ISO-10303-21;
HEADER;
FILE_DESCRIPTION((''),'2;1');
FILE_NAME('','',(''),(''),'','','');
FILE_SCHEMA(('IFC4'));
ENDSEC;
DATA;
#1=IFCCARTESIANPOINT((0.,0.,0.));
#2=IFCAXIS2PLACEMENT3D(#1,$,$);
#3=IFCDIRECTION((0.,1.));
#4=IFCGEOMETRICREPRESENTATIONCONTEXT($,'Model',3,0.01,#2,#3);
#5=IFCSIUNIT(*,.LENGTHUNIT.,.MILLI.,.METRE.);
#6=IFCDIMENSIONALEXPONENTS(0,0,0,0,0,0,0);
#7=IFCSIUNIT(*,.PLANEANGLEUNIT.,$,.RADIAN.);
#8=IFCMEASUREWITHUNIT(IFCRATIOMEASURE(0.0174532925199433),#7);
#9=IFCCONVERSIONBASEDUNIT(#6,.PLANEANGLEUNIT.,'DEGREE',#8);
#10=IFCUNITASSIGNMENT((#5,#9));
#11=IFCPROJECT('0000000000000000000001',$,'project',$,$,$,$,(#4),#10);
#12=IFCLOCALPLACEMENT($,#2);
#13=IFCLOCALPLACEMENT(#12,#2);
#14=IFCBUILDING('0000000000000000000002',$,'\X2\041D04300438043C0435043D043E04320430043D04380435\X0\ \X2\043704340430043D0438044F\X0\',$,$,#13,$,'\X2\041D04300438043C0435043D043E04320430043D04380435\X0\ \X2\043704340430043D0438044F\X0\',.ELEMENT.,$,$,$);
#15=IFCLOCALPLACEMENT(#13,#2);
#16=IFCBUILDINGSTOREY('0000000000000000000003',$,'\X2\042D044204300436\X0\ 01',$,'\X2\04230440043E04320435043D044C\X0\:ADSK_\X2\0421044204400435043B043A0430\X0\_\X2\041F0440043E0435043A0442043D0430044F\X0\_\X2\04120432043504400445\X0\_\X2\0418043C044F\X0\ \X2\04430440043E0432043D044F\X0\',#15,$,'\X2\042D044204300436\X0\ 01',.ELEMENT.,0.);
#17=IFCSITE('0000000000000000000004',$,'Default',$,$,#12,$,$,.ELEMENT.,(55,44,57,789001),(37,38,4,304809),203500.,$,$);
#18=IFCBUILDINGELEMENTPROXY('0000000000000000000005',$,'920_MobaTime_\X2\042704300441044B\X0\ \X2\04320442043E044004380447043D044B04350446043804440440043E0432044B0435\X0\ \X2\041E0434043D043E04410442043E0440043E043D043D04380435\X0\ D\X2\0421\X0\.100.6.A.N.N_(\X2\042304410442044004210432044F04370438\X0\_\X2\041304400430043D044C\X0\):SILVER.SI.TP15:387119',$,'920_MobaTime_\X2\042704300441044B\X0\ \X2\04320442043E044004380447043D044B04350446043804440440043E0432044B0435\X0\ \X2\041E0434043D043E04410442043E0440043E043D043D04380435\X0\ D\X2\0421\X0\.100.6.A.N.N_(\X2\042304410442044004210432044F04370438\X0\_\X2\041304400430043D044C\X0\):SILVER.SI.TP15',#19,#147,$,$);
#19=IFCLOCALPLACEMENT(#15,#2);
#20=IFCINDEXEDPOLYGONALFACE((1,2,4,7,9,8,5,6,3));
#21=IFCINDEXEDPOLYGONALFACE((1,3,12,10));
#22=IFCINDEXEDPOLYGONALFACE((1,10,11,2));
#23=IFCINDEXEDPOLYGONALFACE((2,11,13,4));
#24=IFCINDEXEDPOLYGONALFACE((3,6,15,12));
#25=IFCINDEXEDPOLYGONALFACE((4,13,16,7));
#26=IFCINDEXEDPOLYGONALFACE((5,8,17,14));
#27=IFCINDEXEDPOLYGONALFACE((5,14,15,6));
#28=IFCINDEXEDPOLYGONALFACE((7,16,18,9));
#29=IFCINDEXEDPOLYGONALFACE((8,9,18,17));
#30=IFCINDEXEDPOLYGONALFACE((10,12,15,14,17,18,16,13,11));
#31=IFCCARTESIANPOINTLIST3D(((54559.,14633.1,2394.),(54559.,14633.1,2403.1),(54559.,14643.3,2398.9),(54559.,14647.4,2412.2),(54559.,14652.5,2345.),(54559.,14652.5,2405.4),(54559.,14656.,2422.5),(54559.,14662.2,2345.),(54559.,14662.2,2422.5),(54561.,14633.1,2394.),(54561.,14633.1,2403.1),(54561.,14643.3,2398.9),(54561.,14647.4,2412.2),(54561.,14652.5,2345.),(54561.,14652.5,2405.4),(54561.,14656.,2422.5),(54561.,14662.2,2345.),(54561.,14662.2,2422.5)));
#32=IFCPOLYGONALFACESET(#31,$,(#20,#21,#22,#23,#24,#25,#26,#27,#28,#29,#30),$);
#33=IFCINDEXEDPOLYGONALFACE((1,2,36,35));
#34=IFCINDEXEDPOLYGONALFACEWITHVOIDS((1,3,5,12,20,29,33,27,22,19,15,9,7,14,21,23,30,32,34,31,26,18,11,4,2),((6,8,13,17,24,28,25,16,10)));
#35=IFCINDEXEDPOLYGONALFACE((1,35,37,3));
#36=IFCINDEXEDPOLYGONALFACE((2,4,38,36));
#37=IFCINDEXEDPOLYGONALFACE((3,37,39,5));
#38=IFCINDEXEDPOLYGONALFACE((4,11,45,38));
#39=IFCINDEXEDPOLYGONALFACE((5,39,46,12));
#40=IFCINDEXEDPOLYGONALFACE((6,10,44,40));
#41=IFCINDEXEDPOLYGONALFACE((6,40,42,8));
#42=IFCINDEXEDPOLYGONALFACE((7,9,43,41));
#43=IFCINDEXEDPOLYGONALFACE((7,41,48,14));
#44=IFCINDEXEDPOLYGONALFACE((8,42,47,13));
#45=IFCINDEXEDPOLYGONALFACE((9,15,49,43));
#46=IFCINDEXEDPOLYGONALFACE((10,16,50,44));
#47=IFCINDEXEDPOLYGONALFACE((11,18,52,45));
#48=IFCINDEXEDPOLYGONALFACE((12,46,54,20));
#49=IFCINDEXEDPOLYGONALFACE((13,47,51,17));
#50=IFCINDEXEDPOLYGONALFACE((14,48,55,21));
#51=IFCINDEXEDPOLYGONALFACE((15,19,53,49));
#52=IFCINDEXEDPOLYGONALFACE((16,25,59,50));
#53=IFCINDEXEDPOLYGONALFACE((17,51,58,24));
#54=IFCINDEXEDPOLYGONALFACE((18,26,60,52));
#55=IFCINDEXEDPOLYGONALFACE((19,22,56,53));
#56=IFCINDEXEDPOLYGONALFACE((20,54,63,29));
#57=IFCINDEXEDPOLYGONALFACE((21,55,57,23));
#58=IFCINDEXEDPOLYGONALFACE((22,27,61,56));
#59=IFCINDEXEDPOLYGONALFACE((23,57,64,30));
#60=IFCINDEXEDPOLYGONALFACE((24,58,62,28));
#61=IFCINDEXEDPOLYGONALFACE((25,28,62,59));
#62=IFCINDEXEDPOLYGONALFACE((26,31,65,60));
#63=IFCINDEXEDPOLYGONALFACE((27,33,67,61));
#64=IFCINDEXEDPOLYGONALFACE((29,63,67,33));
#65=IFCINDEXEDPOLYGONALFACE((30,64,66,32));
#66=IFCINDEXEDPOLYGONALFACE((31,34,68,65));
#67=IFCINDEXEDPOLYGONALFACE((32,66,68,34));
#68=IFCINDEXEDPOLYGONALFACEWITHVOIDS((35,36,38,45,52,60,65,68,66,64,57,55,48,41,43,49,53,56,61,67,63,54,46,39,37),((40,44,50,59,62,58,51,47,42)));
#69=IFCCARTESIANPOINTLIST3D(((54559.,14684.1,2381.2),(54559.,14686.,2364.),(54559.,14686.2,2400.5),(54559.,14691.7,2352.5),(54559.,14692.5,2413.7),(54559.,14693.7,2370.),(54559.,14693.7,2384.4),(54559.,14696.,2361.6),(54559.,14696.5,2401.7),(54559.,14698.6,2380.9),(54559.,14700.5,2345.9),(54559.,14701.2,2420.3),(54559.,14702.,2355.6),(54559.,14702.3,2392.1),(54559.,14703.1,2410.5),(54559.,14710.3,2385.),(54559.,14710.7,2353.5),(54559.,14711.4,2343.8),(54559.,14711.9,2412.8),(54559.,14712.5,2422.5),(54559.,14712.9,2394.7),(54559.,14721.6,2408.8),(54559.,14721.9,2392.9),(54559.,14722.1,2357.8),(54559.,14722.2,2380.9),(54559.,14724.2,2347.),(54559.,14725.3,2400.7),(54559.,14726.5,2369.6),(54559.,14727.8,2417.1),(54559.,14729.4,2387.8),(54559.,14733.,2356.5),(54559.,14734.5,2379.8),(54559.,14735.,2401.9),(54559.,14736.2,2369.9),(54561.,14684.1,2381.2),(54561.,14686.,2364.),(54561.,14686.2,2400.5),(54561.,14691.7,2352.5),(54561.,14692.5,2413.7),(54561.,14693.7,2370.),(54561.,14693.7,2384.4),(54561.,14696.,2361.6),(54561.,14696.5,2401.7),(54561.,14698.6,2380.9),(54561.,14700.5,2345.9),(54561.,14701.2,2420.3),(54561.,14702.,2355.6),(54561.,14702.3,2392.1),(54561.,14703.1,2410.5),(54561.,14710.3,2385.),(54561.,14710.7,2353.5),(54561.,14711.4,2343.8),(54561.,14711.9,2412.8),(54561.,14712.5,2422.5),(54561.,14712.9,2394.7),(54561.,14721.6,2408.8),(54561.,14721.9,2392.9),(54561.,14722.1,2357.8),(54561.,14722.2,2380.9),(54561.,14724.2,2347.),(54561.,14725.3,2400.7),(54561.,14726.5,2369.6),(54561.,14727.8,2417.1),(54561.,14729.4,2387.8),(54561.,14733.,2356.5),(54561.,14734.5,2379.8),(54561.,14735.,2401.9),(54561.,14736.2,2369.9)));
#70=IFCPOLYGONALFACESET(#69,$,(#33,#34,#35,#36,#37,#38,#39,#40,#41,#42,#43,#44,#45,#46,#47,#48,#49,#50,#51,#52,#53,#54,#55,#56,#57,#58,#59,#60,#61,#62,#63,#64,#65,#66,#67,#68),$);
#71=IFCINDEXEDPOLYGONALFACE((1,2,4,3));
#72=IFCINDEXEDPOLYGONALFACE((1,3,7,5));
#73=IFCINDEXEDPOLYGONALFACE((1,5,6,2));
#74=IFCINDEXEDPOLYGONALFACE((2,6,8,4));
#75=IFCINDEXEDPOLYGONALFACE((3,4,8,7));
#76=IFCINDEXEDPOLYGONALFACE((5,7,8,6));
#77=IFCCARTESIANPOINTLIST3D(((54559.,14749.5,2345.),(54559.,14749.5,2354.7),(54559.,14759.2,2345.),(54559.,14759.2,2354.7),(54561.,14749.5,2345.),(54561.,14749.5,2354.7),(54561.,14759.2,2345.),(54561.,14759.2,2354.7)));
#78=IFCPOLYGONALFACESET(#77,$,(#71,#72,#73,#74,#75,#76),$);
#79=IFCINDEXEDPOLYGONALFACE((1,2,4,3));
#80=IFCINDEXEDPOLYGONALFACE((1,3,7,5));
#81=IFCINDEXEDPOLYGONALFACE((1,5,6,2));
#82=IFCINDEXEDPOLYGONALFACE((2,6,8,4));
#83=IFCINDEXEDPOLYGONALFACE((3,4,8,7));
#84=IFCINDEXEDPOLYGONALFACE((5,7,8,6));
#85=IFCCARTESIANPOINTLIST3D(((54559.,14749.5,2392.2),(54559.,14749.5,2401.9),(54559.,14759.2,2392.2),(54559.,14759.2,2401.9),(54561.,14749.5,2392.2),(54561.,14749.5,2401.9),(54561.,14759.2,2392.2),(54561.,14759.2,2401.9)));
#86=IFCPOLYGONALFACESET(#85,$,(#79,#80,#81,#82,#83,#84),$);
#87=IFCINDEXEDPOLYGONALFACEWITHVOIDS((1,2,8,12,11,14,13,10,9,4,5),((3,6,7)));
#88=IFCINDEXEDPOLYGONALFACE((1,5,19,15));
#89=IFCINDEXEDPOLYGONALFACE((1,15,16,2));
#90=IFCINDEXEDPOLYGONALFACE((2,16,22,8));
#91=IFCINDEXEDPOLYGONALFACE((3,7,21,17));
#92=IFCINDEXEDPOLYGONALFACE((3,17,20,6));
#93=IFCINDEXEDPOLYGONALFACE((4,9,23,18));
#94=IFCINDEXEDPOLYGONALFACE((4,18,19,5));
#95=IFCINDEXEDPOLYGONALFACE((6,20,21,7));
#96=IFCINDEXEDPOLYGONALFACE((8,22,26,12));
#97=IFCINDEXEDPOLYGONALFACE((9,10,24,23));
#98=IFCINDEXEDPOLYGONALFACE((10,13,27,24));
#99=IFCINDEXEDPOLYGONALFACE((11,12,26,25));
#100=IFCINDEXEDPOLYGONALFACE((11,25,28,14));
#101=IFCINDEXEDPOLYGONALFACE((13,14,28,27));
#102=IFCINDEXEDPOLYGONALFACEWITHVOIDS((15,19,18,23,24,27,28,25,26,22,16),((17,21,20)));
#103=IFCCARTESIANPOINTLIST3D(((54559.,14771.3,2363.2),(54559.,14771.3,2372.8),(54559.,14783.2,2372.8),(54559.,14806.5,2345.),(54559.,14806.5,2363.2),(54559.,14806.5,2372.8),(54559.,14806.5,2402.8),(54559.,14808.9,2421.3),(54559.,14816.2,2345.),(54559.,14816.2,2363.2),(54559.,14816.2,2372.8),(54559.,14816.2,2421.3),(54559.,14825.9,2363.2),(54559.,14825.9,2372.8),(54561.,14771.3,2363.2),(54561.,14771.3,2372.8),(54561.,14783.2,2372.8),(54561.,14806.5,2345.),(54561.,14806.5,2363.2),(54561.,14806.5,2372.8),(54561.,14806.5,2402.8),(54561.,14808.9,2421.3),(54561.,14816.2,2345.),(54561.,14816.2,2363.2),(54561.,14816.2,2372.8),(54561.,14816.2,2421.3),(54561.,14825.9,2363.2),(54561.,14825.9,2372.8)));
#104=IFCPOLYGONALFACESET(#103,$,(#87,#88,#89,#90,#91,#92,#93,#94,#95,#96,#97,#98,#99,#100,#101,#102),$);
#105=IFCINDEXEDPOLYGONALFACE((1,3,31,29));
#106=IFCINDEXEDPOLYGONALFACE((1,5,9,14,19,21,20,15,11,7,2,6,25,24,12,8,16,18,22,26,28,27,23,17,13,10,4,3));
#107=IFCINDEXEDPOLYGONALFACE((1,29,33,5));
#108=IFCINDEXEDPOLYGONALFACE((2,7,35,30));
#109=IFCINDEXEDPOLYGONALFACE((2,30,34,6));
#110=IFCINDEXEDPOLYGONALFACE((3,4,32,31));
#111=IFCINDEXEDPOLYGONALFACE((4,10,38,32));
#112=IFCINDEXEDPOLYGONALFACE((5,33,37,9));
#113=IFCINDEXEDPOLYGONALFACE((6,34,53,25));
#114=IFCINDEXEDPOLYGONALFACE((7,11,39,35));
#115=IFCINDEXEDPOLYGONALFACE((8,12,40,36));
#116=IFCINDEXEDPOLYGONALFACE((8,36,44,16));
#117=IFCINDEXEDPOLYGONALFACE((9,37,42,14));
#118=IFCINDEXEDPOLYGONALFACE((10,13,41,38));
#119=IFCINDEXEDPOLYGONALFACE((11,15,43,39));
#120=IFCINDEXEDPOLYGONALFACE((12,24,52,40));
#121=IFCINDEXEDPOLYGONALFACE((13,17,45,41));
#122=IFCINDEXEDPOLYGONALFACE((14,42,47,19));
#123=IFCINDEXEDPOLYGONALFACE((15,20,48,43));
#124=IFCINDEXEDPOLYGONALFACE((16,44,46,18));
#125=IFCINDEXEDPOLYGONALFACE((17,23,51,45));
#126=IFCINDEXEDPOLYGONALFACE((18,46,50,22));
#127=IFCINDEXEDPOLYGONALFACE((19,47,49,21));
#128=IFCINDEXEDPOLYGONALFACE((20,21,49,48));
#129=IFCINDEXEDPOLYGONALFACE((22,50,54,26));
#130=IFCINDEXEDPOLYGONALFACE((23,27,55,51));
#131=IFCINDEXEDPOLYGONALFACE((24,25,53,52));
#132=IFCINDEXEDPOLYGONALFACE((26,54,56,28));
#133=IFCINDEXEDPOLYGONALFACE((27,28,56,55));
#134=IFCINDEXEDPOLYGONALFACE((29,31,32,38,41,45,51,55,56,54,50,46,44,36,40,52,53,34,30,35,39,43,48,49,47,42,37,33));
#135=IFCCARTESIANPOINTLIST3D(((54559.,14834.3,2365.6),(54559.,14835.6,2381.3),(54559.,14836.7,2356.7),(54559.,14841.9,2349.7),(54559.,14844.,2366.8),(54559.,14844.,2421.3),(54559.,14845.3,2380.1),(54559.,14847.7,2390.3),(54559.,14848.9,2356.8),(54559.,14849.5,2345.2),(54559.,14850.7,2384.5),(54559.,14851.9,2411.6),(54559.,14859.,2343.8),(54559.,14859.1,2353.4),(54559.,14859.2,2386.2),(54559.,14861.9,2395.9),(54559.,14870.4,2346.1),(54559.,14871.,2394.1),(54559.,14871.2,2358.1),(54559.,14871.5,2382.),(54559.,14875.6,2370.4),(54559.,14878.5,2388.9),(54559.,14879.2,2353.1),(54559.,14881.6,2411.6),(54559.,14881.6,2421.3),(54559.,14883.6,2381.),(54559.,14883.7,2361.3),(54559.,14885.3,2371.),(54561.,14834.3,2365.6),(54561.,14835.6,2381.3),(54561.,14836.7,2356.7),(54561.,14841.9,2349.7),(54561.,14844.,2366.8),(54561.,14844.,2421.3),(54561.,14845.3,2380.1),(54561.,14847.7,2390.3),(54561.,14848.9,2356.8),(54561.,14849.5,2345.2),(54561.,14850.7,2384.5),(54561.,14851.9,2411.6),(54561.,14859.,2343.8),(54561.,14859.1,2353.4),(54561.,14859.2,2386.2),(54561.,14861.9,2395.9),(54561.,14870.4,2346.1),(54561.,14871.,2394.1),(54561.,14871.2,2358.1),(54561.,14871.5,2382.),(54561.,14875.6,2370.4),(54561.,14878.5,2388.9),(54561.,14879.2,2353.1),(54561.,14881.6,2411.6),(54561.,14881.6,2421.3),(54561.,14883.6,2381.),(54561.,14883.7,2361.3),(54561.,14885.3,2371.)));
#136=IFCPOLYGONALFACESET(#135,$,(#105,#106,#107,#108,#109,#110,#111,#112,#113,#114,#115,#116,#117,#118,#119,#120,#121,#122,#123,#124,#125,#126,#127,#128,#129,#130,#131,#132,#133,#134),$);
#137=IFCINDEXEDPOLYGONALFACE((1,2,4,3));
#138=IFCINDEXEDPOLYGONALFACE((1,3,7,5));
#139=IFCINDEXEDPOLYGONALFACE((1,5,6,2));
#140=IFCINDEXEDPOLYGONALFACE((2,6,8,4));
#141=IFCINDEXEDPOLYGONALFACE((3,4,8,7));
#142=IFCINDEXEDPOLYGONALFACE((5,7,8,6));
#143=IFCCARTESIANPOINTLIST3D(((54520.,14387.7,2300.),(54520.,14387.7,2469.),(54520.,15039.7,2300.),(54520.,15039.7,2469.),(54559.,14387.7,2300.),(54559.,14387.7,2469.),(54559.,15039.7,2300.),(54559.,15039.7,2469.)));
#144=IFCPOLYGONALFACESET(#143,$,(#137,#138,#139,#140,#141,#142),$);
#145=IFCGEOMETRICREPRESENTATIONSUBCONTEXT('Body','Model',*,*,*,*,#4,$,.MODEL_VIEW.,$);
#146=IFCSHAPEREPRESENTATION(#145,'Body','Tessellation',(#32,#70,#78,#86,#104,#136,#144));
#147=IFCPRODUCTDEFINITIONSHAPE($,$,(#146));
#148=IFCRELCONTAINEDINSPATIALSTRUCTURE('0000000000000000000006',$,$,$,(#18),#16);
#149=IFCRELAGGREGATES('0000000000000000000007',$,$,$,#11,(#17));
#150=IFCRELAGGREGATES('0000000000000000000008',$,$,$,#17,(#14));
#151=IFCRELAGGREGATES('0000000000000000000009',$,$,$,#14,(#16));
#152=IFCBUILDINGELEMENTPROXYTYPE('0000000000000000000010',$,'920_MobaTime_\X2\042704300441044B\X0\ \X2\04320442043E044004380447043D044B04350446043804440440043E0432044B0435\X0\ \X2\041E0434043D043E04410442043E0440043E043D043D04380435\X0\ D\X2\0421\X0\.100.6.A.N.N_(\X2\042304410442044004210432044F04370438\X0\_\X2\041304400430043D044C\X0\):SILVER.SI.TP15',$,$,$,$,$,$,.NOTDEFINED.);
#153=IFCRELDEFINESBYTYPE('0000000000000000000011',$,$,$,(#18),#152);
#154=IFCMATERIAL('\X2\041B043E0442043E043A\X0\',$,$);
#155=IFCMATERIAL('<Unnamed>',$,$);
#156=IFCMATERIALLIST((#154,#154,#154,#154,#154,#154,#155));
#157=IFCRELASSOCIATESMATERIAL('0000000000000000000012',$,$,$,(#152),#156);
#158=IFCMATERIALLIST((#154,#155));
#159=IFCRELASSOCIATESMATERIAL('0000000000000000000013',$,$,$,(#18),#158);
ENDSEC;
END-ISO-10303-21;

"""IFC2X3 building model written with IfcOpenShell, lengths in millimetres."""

from ifc_helpers import new_model, entity, si_unit, converted_unit, direction, frame, origin, origin_2d_with_axis, place, context, subcontext, project, spatial, polyline, rectangle, outline, extrude, source, transform, mapped, material, material_list, type_object, type_shapes, element, save


model = new_model("IFC2X3")

# Units and contexts
model_context = context("Model", 3, precision=0.01, world=origin(), true_north=direction((0.0, 1.0)))
body_context = subcontext(model_context, "Body", "Model", "MODEL_VIEW")
ifc_project = project(units=[si_unit("LENGTHUNIT", "METRE", prefix="MILLI"), converted_unit("PLANEANGLEUNIT", "DEGREE", entity("IfcRatioMeasure", 0.0174532925199433), si_unit("PLANEANGLEUNIT", "RADIAN"), dimensions=[0, 0, 0, 0, 0, 0, 0])], contexts=[model_context])

# Site, building, storey
site_placement = place(None, origin())
site = spatial("IfcSite", under=ifc_project, at=site_placement, Name="Default", CompositionType="ELEMENT", RefLatitude=(55, 44, 57, 789001), RefLongitude=(37, 38, 4, 304809), RefElevation=203500.0)
building_placement = place(site_placement, origin())
building = spatial("IfcBuilding", under=site, at=building_placement, Name="Наименование здания", LongName="Наименование здания", CompositionType="ELEMENT")
storey_placement = place(building_placement, origin())
storey = spatial("IfcBuildingStorey", under=building, at=storey_placement, Name="Этаж 01", ObjectType="Уровень:ADSK_Стрелка_Проектная_Вверх_Имя уровня", LongName="Этаж 01", CompositionType="ELEMENT", Elevation=0.0)

# Building element proxy
ifc_material_1 = material(Name="Лоток")
ifc_material_2 = material(Name="<Unnamed>")
ifc_material_list_1 = material_list([ifc_material_1, ifc_material_1, ifc_material_1, ifc_material_1, ifc_material_1, ifc_material_1, ifc_material_2])
building_element_proxy_type = type_object("IfcBuildingElementProxyType", Name="920_MobaTime_Часы вторичныецифровые Односторонние DС.100.6.A.N.N_(УстрСвязи_Грань):SILVER.SI.TP15", PredefinedType="NOTDEFINED", material=ifc_material_list_1)
shared_shape = source(origin(), body_context, "Body", "SweptSolid", [
    extrude(outline(polyline([(-49.3, -13.1), (28.2, -13.1), (28.2, -6.8), (17.9, 1.8), (8.8, 16.0), (-0.3, 16.0), (4.6, 5.8), (11.1, -3.4), (-49.3, -3.4), (-49.3, -13.1)])), frame((-64.6, 9.8, 39.0), z_axis=(0.0, 0.0, 1.0), x_axis=(0.0, 1.0, 0.0)), (0.0, 0.0, 1.0), 2.0),
    extrude(outline(polyline([(2.2, -27.6), (19.0, -27.6), (30.5, -16.1), (33.3, -4.9), (31.0, 5.8), (21.8, 17.2), (5.2, 27.3), (-11.1, 33.0), (-24.0, 32.7), (-33.6, 27.6), (-40.3, 18.6), (-42.8, 5.7), (-38.0, -6.3), (-27.2, -14.9), (-17.5, -17.7), (-8.2, -16.4), (-0.3, -11.9), (5.1, -4.5), (7.3, 6.2), (4.0, 17.2), (18.4, 7.3), (23.6, -2.4), (22.0, -11.4), (14.2, -18.4), (5.3, -18.3), (2.2, -27.6)]), holes=[polyline([(-9.0, 23.3), (-1.3, 14.3), (-2.5, 2.0), (-11.4, -7.0), (-23.4, -6.0), (-32.2, 2.9), (-31.2, 15.1), (-25.6, 22.1), (-17.5, 24.9), (-9.0, 23.3)])]), frame((-2.7, 3.6, 39.0), z_axis=(0.0, 0.0, 1.0), x_axis=(-0.427649, 0.903945, 0.0)), (0.0, 0.0, 1.0), 2.0),
    extrude(rectangle(XDim=9.7, YDim=9.7, at=origin_2d_with_axis()), frame((40.6, -34.7, 39.0)), (0.0, 0.0, 1.0), 2.0),
    extrude(rectangle(XDim=9.7, YDim=9.7, at=origin_2d_with_axis()), frame((40.6, 12.6, 39.0)), (0.0, 0.0, 1.0), 2.0),
    extrude(outline(polyline([(-0.9, -28.1), (8.8, -28.1), (8.8, -9.9), (18.5, -9.9), (18.5, -0.2), (8.8, -0.2), (8.8, 48.3), (1.5, 48.3), (-36.0, -0.2), (-36.0, -9.9), (-0.9, -9.9), (-0.9, -28.1)]), holes=[polyline([(-0.9, -0.2), (-24.1, -0.2), (-0.9, 29.7), (-0.9, -0.2)])]), frame((93.6, -11.4, 39.0)), (0.0, 0.0, 1.0), 2.0),
    extrude(outline(polyline([(3.3, -28.3), (12.5, -28.3), (20.5, -25.0), (26.8, -18.9), (30.7, -10.0), (31.4, 1.6), (26.9, 11.8), (20.1, 18.4), (11.1, 22.3), (1.0, 23.3), (-7.9, 20.4), (-14.9, 14.5), (-18.9, 6.2), (-17.1, -9.0), (-36.7, 0.5), (-29.1, 29.2), (-38.5, 31.7), (-48.1, -4.6), (-11.6, -23.1), (-8.0, -14.0), (-10.8, -7.6), (-10.2, 1.1), (-3.0, 11.8), (9.2, 12.8), (20.0, 5.5), (21.4, -7.5), (15.5, -16.4), (4.6, -18.6), (3.3, -28.3)])), frame((147.1, -8.5, 39.0), z_axis=(0.0, 0.0, 1.0), x_axis=(0.256974, -0.966418, 0.0)), (0.0, 0.0, 1.0), 2.0),
    extrude(rectangle(XDim=652.0, YDim=169.0, at=origin_2d_with_axis()), frame((0.0, 0.0, 0.0), z_axis=(0.0, 0.0, 1.0), x_axis=(-1.0, 0.0, 0.0)), (0.0, 0.0, 1.0), 39.0),
])
type_shapes(building_element_proxy_type, [shared_shape])
ifc_material_list_2 = material_list([ifc_material_1, ifc_material_2])
for number, where, z_axis, x_axis, name in (
    (1, (54520.0, 14713.7, 2384.5), (1.0, 0.0, 0.0), (0.0, 1.0, 0.0), "920_MobaTime_Часы вторичныецифровые Односторонние DС.100.6.A.N.N_(УстрСвязи_Грань):SILVER.SI.TP15:387119"),
):
    element("IfcBuildingElementProxy", number, at=place(storey_placement, frame(where, z_axis=z_axis, x_axis=x_axis)), inside=storey, type_object=building_element_proxy_type, material=ifc_material_list_2, Name=name, ObjectType="920_MobaTime_Часы вторичныецифровые Односторонние DС.100.6.A.N.N_(УстрСвязи_Грань):SILVER.SI.TP15", context=body_context, shape_type="MappedRepresentation", body=[
        mapped(shared_shape, transform((0.0, 0.0, 0.0), scale=1.0)),
    ])

save(model, "model.ifc")
